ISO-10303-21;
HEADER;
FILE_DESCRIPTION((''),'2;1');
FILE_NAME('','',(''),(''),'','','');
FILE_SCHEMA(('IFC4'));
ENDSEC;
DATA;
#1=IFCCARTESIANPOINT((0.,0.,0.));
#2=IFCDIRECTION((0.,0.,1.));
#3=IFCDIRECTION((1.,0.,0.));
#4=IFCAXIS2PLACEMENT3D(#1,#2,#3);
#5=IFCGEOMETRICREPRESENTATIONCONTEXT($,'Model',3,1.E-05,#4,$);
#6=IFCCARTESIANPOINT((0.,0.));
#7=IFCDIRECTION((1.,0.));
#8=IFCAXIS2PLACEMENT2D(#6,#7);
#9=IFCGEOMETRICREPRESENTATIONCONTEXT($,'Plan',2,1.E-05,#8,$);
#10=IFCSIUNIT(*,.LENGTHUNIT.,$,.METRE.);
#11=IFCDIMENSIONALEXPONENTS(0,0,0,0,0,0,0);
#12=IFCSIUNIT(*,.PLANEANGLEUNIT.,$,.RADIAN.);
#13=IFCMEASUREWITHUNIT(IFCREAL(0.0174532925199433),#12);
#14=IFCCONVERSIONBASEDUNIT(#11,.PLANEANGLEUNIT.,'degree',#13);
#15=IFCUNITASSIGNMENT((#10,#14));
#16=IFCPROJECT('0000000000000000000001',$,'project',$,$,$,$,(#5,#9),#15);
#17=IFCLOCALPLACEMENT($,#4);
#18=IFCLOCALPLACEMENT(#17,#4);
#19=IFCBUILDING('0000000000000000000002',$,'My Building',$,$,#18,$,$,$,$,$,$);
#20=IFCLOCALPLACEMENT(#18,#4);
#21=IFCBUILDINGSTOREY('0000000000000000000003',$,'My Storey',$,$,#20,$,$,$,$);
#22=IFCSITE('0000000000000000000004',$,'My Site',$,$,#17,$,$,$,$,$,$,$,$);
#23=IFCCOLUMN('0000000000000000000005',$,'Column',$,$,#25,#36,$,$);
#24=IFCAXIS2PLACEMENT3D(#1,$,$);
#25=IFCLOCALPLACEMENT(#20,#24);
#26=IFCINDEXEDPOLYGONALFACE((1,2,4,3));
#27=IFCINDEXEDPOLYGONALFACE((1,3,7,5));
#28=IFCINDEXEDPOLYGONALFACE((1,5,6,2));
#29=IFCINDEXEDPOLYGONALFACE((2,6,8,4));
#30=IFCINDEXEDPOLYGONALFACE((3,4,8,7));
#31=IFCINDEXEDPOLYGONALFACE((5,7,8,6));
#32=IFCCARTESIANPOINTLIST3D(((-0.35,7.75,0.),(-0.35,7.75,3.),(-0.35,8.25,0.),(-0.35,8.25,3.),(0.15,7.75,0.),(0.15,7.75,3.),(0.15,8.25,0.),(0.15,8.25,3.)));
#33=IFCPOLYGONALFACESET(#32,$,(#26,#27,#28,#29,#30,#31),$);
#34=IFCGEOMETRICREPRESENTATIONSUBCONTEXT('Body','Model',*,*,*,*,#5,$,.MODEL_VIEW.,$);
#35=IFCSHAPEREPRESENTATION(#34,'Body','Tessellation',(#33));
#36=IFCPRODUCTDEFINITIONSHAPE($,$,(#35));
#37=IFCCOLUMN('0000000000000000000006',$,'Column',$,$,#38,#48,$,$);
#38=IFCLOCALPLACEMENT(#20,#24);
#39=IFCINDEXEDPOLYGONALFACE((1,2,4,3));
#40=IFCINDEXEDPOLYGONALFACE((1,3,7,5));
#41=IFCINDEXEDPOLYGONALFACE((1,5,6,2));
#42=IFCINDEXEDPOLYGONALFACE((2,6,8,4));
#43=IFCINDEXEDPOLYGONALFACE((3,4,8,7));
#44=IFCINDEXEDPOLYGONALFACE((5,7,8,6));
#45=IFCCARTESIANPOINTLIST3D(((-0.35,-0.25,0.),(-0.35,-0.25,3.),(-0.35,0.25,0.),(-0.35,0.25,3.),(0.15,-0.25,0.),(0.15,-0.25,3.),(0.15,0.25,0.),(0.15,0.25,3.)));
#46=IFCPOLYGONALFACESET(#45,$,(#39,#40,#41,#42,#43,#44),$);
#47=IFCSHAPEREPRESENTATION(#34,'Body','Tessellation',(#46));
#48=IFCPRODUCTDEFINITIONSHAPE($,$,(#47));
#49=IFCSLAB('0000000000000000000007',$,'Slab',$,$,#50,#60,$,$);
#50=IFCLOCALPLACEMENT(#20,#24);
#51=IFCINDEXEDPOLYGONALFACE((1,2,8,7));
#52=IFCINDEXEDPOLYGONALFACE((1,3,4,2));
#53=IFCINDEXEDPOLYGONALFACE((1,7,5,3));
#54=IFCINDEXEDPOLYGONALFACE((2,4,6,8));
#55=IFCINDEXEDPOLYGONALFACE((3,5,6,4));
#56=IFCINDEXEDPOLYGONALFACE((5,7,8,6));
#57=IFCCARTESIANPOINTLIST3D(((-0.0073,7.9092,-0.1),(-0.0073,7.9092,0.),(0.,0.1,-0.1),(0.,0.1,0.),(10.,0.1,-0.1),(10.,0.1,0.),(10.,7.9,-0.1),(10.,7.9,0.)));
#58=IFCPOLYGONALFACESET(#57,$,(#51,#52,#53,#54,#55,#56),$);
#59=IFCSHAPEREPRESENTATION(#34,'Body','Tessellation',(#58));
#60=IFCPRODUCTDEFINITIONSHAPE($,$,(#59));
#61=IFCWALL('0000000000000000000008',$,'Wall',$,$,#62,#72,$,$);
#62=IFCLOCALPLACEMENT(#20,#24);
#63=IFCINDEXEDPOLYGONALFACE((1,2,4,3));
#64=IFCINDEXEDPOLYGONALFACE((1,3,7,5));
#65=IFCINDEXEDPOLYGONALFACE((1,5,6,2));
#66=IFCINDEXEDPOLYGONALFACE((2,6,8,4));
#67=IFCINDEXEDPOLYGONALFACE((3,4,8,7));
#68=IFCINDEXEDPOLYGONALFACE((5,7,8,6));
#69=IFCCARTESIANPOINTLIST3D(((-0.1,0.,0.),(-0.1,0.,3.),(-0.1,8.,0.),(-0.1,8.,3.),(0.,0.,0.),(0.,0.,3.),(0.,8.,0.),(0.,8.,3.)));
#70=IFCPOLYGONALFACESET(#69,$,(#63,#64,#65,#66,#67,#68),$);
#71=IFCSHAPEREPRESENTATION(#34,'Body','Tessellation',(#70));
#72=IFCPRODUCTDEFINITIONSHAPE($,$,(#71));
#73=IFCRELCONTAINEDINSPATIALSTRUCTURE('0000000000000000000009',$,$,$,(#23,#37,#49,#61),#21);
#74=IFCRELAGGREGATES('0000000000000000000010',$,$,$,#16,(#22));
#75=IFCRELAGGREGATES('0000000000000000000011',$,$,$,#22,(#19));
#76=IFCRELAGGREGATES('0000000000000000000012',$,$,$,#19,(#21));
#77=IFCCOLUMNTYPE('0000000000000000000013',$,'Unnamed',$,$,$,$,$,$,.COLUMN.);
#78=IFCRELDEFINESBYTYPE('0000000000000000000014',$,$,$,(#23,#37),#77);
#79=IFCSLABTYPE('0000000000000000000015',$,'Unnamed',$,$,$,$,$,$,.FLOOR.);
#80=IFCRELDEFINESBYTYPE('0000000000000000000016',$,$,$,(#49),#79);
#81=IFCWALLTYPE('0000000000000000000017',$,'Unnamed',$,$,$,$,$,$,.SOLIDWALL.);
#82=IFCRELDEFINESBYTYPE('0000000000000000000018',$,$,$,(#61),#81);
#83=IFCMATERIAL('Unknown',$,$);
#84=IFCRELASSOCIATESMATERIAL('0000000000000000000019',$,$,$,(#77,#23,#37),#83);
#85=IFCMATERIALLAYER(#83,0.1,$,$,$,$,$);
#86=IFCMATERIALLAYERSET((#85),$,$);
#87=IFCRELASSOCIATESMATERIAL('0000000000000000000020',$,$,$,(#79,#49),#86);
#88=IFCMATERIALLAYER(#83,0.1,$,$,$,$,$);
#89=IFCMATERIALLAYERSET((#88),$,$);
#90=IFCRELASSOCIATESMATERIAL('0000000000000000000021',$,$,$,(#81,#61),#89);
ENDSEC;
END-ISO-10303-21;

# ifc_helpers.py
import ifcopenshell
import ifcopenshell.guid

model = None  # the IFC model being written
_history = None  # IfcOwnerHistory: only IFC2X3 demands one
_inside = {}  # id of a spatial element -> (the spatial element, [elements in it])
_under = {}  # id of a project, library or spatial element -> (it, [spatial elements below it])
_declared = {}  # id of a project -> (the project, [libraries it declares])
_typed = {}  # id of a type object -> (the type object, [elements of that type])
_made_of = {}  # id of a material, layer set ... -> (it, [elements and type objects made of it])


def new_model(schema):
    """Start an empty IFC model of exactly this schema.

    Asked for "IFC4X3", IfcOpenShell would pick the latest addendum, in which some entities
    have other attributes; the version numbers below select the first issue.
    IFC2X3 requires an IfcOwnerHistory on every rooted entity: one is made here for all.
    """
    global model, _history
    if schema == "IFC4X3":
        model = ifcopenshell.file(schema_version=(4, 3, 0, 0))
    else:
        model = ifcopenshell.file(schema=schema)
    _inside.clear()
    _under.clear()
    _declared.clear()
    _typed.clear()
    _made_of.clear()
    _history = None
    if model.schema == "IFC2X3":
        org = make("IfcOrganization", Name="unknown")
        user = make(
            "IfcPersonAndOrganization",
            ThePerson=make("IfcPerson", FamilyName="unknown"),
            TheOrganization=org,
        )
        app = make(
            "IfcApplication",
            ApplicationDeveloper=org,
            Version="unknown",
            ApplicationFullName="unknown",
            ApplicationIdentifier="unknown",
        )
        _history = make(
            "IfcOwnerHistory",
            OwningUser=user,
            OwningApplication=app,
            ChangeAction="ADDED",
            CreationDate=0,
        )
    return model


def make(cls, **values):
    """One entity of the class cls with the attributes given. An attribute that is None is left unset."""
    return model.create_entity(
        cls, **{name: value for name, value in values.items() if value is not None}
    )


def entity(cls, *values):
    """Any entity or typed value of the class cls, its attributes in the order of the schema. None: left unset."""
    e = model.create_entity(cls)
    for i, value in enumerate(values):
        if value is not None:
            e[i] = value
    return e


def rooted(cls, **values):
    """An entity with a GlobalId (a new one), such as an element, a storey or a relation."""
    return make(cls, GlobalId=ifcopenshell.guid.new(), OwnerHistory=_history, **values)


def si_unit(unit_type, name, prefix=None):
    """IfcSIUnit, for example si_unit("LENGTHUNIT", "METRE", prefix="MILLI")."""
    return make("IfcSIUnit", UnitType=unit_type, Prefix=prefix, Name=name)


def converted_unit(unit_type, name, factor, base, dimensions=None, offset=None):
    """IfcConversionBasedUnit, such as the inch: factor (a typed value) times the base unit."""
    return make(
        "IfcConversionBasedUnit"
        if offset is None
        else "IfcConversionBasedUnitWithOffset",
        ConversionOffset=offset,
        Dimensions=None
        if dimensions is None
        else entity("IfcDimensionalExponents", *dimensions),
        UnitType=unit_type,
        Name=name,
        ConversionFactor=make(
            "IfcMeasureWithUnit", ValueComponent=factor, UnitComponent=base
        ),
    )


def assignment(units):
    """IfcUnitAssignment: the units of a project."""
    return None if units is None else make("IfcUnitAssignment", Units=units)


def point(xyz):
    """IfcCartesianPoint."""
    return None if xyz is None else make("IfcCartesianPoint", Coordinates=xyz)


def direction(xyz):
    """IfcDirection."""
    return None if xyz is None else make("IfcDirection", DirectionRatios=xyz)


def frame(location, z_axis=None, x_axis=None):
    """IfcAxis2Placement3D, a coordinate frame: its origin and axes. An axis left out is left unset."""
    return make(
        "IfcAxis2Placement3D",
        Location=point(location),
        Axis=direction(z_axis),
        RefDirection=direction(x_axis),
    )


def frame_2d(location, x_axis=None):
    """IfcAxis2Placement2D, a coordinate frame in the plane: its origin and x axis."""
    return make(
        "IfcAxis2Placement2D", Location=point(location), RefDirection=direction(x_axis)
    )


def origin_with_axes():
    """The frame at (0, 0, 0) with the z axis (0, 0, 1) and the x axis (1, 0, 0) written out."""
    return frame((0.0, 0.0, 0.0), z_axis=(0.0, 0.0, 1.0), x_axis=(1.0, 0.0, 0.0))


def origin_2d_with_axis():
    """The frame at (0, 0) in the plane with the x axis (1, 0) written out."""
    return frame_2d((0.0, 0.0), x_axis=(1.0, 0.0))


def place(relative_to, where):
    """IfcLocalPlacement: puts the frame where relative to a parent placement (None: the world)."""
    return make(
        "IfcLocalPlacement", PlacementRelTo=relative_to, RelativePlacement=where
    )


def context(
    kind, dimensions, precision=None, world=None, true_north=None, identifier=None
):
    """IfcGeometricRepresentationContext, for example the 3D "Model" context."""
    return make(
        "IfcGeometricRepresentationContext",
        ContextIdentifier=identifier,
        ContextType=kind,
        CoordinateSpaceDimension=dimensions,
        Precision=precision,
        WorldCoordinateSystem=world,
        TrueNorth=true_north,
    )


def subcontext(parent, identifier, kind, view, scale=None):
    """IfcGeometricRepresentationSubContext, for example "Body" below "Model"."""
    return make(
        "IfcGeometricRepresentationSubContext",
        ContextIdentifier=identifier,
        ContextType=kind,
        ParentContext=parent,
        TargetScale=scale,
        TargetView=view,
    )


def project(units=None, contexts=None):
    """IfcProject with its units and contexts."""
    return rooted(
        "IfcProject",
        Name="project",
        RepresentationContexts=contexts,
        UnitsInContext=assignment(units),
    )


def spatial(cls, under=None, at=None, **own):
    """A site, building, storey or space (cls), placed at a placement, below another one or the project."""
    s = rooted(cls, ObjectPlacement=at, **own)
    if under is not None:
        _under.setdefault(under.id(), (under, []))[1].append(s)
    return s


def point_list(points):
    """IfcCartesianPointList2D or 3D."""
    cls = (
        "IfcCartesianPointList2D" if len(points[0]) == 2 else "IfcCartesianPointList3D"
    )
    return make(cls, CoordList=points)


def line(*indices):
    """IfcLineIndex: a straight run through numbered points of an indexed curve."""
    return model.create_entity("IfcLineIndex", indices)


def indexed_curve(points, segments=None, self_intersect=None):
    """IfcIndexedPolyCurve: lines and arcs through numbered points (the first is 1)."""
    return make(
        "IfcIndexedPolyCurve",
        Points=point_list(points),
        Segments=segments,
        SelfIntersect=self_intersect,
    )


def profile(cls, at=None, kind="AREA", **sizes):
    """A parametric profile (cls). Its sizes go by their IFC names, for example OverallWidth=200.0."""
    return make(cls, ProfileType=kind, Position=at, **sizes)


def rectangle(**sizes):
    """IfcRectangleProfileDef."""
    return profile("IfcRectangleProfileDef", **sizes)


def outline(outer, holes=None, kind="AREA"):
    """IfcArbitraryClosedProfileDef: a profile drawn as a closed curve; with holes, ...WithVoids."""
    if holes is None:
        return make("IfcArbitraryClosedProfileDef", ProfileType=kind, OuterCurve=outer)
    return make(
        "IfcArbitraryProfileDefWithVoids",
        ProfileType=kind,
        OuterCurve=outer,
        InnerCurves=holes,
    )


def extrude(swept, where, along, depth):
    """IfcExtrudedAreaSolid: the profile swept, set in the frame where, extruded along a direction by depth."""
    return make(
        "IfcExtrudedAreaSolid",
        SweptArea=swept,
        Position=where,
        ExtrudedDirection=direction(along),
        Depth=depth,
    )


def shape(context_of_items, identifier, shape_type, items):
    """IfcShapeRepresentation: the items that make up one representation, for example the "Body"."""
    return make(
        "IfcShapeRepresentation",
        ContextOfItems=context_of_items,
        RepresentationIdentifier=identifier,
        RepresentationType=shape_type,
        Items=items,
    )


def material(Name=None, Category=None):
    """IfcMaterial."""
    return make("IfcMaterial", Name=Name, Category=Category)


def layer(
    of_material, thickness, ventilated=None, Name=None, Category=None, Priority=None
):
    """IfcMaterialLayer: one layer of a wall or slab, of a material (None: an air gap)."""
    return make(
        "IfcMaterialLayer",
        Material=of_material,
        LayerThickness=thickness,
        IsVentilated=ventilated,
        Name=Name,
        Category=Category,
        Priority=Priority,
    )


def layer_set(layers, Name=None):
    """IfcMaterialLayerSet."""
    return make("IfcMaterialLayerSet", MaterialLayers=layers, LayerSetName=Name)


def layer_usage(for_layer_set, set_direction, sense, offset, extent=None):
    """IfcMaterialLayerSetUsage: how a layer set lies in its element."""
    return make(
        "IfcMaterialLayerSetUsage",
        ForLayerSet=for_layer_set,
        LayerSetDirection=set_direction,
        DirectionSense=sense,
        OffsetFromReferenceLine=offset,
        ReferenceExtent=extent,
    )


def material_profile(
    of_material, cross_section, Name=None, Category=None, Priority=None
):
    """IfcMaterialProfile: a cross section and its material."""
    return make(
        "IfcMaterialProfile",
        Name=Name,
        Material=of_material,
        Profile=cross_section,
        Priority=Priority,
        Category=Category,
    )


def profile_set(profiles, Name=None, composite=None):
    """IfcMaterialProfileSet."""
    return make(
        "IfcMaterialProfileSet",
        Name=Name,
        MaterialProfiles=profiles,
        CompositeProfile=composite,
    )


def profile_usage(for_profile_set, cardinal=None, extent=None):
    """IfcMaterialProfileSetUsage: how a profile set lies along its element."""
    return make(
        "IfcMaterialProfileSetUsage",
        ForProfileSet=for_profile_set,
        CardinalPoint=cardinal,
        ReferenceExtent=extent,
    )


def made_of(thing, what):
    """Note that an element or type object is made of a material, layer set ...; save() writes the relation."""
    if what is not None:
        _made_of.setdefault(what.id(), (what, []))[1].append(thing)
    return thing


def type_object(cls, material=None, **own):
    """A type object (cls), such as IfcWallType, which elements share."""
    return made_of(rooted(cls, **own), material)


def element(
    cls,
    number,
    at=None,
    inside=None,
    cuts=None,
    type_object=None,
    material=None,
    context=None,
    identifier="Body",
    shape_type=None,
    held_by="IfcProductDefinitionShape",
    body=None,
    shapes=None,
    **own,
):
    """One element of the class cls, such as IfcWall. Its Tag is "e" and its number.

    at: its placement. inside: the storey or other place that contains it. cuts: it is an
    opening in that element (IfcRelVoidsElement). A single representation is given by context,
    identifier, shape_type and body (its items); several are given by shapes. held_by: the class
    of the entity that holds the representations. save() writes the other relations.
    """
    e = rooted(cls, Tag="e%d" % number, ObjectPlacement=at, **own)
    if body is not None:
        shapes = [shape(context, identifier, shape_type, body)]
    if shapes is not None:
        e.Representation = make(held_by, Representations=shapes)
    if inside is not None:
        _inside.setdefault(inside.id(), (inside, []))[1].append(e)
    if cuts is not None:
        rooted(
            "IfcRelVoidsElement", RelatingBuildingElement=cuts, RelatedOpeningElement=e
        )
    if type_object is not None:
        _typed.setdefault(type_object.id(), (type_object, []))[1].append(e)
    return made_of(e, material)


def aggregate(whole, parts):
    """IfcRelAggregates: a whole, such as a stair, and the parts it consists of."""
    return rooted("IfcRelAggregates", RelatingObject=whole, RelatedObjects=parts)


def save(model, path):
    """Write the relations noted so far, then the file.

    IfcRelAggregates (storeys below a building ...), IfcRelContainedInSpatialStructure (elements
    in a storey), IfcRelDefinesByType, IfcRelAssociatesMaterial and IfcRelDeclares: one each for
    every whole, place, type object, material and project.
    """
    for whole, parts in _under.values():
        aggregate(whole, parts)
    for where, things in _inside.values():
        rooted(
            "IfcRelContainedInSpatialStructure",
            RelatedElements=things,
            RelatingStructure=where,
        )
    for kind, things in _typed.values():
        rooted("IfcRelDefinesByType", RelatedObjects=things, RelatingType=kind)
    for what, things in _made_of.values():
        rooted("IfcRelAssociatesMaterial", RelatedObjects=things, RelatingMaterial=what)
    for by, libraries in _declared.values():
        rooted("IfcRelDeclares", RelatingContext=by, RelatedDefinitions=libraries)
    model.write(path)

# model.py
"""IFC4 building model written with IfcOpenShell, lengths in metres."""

from ifc_helpers import new_model, entity, si_unit, converted_unit, frame, origin_with_axes, origin_2d_with_axis, place, context, subcontext, project, spatial, line, indexed_curve, rectangle, outline, extrude, material, layer, layer_set, layer_usage, material_profile, profile_set, profile_usage, type_object, element, save


model = new_model("IFC4")

# Units and contexts
model_context = context("Model", 3, precision=1e-05, world=origin_with_axes())
plan_context = context("Plan", 2, precision=1e-05, world=origin_2d_with_axis())
body_context_1 = subcontext(model_context, "Body", "Model", "MODEL_VIEW")
ifc_project = project(units=[si_unit("LENGTHUNIT", "METRE"), converted_unit("PLANEANGLEUNIT", "degree", entity("IfcReal", 0.0174532925199433), si_unit("PLANEANGLEUNIT", "RADIAN"), dimensions=[0, 0, 0, 0, 0, 0, 0])], contexts=[model_context, plan_context])

# Site, building, storey
site_placement = place(None, origin_with_axes())
site = spatial("IfcSite", under=ifc_project, at=site_placement, Name="My Site")
building_placement = place(site_placement, origin_with_axes())
building = spatial("IfcBuilding", under=site, at=building_placement, Name="My Building")
storey_placement = place(building_placement, origin_with_axes())
storey = spatial("IfcBuildingStorey", under=building, at=storey_placement, Name="My Storey")

# Columns
ifc_material = material(Name="Unknown")
ifc_material_profile = material_profile(ifc_material, rectangle(XDim=0.5, YDim=0.5))
ifc_profile_set = profile_set([ifc_material_profile])
ifc_profile_usage_1 = profile_usage(ifc_profile_set, cardinal=5)
column_type = type_object("IfcColumnType", Name="Unnamed", PredefinedType="COLUMN", material=ifc_profile_set)
column_1_placement = place(storey_placement, frame((-0.1, 8.0, 0.0), z_axis=(0.0, 0.0, 1.0), x_axis=(1.0, 0.0, 0.0)))
element("IfcColumn", 1, at=column_1_placement, inside=storey, type_object=column_type, material=ifc_profile_usage_1, Name="Column", context=body_context_1, shape_type="SweptSolid", body=[
    extrude(rectangle(XDim=0.5, YDim=0.5), origin_with_axes(), (0.0, 0.0, 1.0), 3.0),
])
ifc_profile_usage_2 = profile_usage(ifc_profile_set, cardinal=5)
column_2_placement = place(storey_placement, frame((-0.1, 0.0, 0.0), z_axis=(0.0, 0.0, 1.0), x_axis=(1.0, 0.0, 0.0)))
element("IfcColumn", 2, at=column_2_placement, inside=storey, type_object=column_type, material=ifc_profile_usage_2, Name="Column", context=body_context_1, shape_type="SweptSolid", body=[
    extrude(rectangle(XDim=0.5, YDim=0.5), origin_with_axes(), (0.0, 0.0, 1.0), 3.0),
])

# Slab
ifc_layer_1 = layer(ifc_material, 0.1)
ifc_layer_set_1 = layer_set([ifc_layer_1])
ifc_layer_usage_1 = layer_usage(ifc_layer_set_1, "AXIS3", "POSITIVE", -0.1)
slab_type = type_object("IfcSlabType", Name="Unnamed", PredefinedType="FLOOR", material=ifc_layer_set_1)
slab_placement = place(storey_placement, frame((-0.0073, 7.9092, 0.0), z_axis=(0.0, 0.0, 1.0), x_axis=(1.0, 0.0, 0.0)))
element("IfcSlab", 3, at=slab_placement, inside=storey, type_object=slab_type, material=ifc_layer_usage_1, Name="Slab", context=body_context_1, shape_type="SweptSolid", body=[
    extrude(outline(indexed_curve([(0.0, 0.0), (0.0073, -7.8092), (10.0073, -7.8092), (10.0073, -0.0092), (0.0, 0.0)])), frame((0.0, 0.0, -0.1), z_axis=(0.0, 0.0, 1.0), x_axis=(1.0, 0.0, 0.0)), (0.0, 0.0, 1.0), 0.1),
])

# Shared definitions
ifc_layer_2 = layer(ifc_material, 0.1)
ifc_layer_set_2 = layer_set([ifc_layer_2])
wall_type = type_object("IfcWallType", Name="Unnamed", PredefinedType="SOLIDWALL", material=ifc_layer_set_2)

# Wall
ifc_layer_usage_2 = layer_usage(ifc_layer_set_2, "AXIS2", "POSITIVE", 0.0)
wall_1_placement = place(storey_placement, frame((0.0, 0.0, 0.0), z_axis=(0.0, 0.0, 1.0), x_axis=(0.0, 1.0, 0.0)))
element("IfcWall", 4, at=wall_1_placement, inside=storey, type_object=wall_type, material=ifc_layer_usage_2, Name="Wall", context=body_context_1, shape_type="SweptSolid", body=[
    extrude(outline(indexed_curve([(0.0, 0.0), (0.0, 0.1), (8.0, 0.1), (8.0, 0.0)], segments=[line(1, 2, 3, 4, 1)])), origin_with_axes(), (0.0, 0.0, 1.0), 3.0),
])

save(model, "model.ifc")
